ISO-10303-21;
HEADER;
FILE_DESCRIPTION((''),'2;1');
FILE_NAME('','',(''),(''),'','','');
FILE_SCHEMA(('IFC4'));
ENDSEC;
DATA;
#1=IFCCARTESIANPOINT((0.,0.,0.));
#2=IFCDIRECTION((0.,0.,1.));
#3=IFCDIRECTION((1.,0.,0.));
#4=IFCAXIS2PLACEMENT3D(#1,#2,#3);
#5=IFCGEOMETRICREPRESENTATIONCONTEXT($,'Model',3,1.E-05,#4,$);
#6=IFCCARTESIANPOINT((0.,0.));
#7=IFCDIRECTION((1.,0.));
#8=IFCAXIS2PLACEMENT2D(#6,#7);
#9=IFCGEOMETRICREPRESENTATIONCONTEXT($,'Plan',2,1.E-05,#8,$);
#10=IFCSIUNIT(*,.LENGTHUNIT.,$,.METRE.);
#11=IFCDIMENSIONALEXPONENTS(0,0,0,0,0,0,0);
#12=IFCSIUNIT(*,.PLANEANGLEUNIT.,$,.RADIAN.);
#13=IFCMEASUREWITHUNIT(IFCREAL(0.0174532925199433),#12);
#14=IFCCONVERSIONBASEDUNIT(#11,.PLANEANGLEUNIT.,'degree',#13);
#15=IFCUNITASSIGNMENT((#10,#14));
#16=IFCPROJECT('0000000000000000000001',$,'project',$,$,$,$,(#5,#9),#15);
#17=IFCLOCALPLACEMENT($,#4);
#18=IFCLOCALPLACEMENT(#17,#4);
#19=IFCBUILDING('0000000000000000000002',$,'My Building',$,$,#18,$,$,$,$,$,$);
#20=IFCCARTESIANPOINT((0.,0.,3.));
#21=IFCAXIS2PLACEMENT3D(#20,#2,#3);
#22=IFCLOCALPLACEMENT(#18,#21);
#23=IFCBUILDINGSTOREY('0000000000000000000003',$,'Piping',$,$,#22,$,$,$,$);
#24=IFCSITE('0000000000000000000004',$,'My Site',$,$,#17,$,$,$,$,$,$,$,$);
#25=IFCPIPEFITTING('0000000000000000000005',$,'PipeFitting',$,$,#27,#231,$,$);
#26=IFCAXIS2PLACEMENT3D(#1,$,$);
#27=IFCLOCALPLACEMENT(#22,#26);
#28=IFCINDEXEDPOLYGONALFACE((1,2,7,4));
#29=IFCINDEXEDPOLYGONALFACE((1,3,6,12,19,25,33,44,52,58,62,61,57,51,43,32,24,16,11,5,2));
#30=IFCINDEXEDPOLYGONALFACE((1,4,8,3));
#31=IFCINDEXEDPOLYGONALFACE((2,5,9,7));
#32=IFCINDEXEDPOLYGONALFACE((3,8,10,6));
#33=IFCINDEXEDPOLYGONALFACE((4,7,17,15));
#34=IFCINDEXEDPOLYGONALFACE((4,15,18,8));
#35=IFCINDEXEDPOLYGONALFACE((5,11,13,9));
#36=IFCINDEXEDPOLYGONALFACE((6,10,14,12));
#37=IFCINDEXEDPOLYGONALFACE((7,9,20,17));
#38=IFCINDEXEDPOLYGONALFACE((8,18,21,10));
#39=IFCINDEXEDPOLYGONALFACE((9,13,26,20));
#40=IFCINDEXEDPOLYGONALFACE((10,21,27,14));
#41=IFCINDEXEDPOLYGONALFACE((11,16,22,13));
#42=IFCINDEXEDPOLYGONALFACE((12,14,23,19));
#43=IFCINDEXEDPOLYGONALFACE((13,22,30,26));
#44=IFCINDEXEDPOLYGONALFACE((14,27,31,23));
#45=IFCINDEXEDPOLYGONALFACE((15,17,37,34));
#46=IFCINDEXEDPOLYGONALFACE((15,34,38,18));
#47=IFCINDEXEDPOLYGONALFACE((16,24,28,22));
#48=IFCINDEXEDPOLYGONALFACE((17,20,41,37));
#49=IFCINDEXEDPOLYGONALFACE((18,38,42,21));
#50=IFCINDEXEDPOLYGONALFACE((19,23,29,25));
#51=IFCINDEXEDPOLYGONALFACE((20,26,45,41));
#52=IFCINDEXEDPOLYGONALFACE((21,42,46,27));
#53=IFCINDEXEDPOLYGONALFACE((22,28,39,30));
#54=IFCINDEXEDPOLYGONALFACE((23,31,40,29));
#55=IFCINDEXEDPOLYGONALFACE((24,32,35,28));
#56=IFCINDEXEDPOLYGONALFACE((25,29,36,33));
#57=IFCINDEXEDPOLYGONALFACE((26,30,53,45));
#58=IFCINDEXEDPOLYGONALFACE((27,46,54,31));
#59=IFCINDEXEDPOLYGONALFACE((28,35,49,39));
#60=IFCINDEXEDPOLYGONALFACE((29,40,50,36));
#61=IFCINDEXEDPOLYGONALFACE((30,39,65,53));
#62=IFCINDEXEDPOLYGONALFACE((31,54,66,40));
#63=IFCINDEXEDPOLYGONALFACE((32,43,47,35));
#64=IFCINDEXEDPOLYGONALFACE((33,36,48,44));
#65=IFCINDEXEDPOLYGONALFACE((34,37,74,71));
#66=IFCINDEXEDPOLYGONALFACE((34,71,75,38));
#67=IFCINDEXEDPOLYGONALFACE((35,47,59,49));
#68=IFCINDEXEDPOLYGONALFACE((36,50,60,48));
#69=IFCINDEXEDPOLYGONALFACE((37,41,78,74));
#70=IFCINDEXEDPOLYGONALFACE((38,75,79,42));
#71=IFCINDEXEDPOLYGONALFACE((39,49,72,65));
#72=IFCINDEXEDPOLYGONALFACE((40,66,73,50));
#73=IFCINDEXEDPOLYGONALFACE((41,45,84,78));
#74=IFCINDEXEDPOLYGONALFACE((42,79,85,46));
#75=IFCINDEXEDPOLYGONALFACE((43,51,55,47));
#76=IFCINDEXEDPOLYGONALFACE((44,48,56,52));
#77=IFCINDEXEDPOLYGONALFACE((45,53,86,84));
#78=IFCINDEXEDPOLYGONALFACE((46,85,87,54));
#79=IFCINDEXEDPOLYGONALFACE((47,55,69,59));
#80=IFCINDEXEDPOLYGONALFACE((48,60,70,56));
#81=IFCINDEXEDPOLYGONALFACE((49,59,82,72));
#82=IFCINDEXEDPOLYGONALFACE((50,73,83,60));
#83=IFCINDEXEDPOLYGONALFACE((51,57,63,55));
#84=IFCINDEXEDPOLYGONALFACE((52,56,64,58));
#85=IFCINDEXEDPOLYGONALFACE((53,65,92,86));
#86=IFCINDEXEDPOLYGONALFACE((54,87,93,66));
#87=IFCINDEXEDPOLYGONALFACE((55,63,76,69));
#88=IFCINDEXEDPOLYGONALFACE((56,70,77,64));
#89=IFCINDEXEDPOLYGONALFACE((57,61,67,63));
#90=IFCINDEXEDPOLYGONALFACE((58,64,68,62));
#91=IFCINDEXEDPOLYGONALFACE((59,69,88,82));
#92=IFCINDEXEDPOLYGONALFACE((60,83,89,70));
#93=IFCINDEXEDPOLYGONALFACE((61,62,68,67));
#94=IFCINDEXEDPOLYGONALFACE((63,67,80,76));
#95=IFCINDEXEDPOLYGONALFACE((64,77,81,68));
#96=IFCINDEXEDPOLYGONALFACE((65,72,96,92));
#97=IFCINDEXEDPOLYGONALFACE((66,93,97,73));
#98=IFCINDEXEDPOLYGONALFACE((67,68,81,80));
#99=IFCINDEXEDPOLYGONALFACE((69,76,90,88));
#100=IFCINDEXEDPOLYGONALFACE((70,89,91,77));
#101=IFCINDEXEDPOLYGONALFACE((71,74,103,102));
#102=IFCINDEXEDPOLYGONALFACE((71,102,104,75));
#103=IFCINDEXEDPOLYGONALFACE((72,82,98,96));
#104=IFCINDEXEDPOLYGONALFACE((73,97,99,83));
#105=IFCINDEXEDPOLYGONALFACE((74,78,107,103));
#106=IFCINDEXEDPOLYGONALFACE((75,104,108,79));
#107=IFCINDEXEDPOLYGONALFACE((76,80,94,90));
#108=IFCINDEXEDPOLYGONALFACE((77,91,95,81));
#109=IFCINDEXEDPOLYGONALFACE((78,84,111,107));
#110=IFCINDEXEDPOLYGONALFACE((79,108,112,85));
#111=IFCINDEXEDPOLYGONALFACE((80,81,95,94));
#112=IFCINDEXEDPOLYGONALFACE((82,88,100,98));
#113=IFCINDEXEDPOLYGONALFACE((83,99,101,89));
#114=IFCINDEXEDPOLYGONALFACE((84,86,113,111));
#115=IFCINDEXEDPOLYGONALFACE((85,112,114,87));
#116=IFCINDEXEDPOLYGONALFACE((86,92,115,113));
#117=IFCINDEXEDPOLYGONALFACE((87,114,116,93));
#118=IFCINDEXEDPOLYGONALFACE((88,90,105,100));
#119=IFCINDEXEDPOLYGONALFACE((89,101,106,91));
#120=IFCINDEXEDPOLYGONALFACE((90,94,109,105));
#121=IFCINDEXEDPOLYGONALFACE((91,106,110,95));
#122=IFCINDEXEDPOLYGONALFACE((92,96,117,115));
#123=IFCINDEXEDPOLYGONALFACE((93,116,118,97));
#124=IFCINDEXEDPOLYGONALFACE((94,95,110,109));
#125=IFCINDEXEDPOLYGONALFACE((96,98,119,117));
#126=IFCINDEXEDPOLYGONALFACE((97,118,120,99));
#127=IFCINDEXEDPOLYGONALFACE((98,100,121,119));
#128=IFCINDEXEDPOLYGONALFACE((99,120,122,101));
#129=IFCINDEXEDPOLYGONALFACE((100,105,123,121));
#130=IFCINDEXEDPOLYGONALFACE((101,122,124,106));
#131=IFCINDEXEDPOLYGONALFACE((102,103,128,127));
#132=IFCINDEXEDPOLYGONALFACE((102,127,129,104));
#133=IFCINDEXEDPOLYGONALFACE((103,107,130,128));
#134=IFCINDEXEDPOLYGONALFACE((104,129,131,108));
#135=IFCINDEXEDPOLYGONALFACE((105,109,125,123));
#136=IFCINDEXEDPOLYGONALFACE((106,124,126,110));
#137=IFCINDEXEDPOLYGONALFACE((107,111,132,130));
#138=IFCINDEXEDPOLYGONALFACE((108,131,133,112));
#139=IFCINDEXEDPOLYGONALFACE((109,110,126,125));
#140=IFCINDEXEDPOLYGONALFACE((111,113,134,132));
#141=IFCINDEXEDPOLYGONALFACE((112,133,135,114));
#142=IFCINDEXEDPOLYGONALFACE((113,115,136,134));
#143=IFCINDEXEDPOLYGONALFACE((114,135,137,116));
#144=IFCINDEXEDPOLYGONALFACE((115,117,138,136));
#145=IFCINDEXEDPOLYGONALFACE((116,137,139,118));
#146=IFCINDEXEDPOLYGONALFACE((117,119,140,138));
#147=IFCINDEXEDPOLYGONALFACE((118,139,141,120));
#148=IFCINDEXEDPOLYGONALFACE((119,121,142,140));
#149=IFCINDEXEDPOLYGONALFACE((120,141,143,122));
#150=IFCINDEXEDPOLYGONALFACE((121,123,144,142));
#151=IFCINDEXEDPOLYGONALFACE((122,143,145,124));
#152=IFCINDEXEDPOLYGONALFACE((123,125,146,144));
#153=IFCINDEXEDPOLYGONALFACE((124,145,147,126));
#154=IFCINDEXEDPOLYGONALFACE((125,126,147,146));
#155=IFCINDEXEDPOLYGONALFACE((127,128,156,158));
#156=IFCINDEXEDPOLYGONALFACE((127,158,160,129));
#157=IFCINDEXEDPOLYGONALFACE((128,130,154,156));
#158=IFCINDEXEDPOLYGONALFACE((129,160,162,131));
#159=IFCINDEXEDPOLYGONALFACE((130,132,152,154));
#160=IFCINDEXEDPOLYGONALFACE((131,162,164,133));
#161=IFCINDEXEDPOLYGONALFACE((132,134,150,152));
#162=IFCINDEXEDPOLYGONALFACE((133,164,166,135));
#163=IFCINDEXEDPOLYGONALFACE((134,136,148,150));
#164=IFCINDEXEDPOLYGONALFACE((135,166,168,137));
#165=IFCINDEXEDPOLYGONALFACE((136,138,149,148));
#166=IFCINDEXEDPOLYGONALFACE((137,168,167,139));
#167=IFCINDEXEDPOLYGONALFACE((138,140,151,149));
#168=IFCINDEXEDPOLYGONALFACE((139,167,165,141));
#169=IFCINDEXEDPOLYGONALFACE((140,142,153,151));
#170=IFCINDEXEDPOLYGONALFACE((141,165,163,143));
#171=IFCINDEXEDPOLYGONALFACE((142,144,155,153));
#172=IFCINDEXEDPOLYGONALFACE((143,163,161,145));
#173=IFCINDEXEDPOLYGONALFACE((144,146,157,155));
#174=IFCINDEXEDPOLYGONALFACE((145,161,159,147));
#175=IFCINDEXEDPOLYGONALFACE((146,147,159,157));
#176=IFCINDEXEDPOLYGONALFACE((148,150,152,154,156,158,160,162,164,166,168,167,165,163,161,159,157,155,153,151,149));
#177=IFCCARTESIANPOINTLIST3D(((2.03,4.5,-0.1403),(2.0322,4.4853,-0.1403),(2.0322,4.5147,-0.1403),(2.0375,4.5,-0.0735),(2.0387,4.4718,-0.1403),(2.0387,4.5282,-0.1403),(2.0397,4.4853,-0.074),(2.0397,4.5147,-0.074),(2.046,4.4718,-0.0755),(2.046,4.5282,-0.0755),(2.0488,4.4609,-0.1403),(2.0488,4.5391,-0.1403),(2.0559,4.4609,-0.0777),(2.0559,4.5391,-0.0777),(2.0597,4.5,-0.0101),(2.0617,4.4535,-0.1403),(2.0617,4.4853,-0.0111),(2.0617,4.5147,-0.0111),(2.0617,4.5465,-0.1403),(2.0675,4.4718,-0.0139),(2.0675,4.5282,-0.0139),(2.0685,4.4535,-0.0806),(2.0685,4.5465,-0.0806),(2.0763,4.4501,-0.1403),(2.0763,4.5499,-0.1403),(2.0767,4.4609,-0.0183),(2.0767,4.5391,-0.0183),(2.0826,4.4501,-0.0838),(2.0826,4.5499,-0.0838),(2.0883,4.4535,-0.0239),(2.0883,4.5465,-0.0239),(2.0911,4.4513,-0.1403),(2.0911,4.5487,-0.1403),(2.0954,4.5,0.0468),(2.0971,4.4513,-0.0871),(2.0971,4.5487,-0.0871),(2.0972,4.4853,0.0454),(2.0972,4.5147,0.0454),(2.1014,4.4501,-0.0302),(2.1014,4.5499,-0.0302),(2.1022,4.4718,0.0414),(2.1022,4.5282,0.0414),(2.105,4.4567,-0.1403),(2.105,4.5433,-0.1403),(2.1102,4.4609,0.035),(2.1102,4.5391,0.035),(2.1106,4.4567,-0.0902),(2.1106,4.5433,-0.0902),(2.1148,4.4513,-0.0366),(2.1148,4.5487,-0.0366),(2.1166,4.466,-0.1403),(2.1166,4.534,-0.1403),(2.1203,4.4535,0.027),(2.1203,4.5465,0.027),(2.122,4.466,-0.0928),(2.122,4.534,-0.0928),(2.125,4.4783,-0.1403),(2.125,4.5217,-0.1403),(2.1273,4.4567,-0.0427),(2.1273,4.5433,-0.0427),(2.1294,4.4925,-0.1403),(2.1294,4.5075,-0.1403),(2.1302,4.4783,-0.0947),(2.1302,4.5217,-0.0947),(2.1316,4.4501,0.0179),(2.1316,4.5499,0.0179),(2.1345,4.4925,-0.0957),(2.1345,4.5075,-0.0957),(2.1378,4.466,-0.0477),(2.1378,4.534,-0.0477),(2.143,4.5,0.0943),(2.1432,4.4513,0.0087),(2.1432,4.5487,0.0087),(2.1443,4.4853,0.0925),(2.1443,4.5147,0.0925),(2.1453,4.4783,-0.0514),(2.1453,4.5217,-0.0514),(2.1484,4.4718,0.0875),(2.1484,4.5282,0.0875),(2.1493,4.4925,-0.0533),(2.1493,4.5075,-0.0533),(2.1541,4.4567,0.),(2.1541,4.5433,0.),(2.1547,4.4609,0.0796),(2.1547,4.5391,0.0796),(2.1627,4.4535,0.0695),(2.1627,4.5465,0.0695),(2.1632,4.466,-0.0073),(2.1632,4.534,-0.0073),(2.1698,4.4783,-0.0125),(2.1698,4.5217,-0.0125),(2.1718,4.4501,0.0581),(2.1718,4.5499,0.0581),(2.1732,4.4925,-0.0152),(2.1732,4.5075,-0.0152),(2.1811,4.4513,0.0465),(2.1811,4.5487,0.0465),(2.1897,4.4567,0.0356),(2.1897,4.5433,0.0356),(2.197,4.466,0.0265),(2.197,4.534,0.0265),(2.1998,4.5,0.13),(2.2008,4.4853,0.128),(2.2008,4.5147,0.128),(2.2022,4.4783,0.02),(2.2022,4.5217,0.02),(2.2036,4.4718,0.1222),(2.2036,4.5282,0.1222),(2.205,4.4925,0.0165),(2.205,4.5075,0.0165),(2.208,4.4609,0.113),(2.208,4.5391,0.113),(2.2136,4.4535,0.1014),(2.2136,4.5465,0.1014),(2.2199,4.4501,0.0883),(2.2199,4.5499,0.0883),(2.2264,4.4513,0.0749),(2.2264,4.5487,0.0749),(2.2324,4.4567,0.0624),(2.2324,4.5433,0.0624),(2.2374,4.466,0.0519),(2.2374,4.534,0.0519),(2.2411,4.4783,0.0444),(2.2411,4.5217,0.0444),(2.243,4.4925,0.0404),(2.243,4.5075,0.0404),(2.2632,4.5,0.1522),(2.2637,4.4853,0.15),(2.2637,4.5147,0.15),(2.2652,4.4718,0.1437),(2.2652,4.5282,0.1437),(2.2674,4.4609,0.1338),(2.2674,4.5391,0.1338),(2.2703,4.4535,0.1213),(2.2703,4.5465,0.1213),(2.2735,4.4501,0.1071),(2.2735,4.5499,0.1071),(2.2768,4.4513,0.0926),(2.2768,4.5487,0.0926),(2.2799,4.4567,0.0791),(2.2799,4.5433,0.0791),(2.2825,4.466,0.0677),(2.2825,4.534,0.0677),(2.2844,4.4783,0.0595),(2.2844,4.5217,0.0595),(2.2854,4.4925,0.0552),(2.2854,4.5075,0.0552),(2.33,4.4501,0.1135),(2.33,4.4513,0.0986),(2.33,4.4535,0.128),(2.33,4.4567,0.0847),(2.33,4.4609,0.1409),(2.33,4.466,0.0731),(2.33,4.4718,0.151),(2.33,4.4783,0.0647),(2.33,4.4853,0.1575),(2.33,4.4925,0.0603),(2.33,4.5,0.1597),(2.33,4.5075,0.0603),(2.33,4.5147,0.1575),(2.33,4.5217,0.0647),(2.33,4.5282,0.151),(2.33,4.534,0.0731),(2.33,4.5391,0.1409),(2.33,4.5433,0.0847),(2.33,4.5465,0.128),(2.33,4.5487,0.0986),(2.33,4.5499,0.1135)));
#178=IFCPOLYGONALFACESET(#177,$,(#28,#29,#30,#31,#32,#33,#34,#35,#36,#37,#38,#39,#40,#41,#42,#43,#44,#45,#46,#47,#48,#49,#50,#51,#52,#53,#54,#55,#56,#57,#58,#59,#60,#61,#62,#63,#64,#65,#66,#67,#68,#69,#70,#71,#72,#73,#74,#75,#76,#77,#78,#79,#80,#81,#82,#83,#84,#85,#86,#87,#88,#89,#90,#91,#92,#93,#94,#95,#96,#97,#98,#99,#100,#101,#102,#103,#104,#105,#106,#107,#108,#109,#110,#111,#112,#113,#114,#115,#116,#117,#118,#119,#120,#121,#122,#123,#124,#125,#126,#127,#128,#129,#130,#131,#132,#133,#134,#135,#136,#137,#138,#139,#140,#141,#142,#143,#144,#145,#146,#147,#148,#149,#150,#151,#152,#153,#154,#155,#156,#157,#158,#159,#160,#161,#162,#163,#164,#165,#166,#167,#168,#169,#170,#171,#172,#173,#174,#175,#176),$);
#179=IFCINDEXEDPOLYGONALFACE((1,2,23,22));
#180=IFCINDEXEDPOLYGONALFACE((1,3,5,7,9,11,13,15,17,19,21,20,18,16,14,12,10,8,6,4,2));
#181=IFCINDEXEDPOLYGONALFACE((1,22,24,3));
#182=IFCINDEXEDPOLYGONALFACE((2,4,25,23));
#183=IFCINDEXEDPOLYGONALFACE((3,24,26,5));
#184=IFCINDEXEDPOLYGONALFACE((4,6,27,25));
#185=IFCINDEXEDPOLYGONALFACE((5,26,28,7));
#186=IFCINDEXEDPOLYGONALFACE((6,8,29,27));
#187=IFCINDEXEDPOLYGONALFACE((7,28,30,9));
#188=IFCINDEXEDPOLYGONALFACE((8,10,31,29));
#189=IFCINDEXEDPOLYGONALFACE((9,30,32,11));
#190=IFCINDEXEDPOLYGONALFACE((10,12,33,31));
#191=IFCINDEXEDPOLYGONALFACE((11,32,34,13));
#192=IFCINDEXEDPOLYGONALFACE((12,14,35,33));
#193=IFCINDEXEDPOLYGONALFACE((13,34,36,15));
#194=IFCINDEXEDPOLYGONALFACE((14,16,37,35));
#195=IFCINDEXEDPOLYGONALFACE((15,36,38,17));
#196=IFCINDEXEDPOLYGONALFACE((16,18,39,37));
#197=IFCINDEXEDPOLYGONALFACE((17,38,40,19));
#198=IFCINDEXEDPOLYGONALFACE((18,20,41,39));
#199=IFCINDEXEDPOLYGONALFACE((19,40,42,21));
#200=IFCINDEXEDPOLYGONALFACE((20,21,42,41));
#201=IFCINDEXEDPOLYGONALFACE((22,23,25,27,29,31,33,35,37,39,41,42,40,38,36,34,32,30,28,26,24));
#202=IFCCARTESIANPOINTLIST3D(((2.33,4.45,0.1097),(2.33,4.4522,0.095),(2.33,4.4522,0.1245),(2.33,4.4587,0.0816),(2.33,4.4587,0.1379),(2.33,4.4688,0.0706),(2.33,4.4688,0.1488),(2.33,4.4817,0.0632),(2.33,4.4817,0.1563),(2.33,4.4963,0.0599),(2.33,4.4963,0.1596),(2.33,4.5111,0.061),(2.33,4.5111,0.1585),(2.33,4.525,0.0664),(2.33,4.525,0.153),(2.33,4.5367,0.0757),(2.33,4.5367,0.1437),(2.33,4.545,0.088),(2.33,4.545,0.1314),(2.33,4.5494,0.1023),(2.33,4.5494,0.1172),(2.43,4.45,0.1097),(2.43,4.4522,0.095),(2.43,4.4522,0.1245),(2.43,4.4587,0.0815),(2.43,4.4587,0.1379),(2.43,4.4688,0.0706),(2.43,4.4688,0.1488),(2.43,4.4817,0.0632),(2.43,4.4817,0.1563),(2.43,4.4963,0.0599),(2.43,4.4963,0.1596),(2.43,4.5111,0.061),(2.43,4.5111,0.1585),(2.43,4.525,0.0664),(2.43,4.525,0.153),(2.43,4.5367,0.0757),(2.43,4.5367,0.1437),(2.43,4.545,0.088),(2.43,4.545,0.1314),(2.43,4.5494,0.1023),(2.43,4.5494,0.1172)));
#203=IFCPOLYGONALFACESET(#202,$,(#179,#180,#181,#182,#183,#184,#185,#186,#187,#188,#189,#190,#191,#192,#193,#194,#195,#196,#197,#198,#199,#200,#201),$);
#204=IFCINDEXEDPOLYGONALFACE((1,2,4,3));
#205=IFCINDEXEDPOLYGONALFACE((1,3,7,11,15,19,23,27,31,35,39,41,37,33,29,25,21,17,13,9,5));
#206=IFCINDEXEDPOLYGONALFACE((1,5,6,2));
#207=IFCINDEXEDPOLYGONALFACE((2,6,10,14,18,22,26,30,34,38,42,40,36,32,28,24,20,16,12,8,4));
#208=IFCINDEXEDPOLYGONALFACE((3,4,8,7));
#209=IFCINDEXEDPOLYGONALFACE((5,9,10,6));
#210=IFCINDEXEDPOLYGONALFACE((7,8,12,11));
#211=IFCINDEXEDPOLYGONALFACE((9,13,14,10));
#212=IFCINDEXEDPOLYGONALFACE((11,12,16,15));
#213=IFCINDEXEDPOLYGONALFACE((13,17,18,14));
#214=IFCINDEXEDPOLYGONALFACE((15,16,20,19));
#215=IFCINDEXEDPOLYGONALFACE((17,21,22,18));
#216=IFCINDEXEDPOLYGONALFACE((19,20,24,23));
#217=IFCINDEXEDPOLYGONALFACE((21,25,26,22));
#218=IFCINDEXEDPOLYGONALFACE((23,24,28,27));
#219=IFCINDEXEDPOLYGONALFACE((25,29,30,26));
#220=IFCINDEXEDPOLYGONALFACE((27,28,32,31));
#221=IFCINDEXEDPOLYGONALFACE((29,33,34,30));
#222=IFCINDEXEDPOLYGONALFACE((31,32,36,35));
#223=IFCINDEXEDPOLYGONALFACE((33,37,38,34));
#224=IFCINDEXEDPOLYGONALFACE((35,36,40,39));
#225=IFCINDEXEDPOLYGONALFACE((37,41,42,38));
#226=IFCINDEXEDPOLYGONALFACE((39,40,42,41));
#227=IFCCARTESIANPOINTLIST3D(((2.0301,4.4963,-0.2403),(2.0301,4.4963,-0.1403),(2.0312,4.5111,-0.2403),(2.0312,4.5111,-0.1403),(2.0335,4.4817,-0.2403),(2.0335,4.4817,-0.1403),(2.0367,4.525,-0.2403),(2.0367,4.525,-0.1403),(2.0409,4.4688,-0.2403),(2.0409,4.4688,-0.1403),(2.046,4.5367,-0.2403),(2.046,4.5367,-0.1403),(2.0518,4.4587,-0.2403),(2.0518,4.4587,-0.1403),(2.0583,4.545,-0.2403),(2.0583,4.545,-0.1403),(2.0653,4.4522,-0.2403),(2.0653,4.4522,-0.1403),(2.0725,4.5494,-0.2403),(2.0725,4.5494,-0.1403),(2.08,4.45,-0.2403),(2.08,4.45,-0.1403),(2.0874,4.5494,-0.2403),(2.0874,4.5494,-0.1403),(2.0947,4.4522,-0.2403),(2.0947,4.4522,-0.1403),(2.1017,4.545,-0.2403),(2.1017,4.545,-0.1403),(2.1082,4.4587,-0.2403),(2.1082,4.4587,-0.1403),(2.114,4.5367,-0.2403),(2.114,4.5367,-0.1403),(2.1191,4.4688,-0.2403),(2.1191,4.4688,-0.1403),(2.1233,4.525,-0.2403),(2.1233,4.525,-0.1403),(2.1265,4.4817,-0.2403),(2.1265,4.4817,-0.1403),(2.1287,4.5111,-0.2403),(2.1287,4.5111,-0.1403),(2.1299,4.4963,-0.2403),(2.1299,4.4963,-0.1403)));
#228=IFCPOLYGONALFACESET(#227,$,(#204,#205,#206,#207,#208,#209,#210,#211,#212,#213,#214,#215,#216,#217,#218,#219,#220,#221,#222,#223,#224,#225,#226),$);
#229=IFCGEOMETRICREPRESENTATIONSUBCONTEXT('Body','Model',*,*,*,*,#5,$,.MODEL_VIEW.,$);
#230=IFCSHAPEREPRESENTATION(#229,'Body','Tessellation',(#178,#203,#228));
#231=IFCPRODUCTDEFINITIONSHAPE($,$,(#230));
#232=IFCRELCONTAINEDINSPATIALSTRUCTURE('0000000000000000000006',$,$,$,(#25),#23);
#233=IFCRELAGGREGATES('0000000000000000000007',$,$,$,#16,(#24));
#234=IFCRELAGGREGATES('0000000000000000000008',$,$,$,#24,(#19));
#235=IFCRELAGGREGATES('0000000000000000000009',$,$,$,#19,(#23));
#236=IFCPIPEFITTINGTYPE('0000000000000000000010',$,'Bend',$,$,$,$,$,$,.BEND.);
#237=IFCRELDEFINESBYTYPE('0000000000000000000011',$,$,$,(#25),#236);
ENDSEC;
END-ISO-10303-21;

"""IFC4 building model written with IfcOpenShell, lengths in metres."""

from ifc_helpers import new_model, entity, si_unit, converted_unit, frame, origin_with_axes, origin_2d_with_axis, place, context, subcontext, project, spatial, circle, extrude, source, transform, mapped, type_object, type_shapes, element, save


model = new_model("IFC4")

# Units and contexts
model_context = context("Model", 3, precision=1e-05, world=origin_with_axes())
plan_context = context("Plan", 2, precision=1e-05, world=origin_2d_with_axis())
body_context = subcontext(model_context, "Body", "Model", "MODEL_VIEW")
ifc_project = project(units=[si_unit("LENGTHUNIT", "METRE"), converted_unit("PLANEANGLEUNIT", "degree", entity("IfcReal", 0.0174532925199433), si_unit("PLANEANGLEUNIT", "RADIAN"), dimensions=[0, 0, 0, 0, 0, 0, 0])], contexts=[model_context, plan_context])

# Site, building, storey
site_placement = place(None, origin_with_axes())
site = spatial("IfcSite", under=ifc_project, at=site_placement, Name="My Site")
building_placement = place(site_placement, origin_with_axes())
building = spatial("IfcBuilding", under=site, at=building_placement, Name="My Building")
storey_placement = place(building_placement, frame((0.0, 0.0, 3.0), z_axis=(0.0, 0.0, 1.0), x_axis=(1.0, 0.0, 0.0)))
storey = spatial("IfcBuildingStorey", under=building, at=storey_placement, Name="Piping")

# Pipe fitting
pipe_fitting_type_1 = type_object("IfcPipeFittingType", Name="Bend", PredefinedType="BEND")
shared_shape_1 = source(origin_with_axes(), body_context, "Body", "SolidModel", [
    entity("IfcSweptDiskSolid", entity("IfcIndexedPolyCurve", entity("IfcCartesianPointList3D", [[0.0, 0.0, 0.1], [0.0, -0.0732, 0.2768], [0.0, -0.25, 0.35]]), [entity("IfcArcIndex", [1, 2, 3])]), 0.05),
    extrude(circle(Radius=0.05), origin_with_axes(), (0.0, 0.0, 1.0), 0.1),
    extrude(circle(Radius=0.05), frame((0.0, -0.25, 0.35), z_axis=(0.0, -1.0, -0.000021), x_axis=(1.0, 0.0, 0.0)), (0.0, 0.0, 1.0), 0.1),
])
type_shapes(pipe_fitting_type_1, [shared_shape_1])
for number, where, z_axis, x_axis, name in (
    (1, (2.43, 4.5, 0.1097), (-1.0, 0.0, 0.000021), (0.0, -1.0, 0.0), "PipeFitting"),
):
    element("IfcPipeFitting", number, at=place(storey_placement, frame(where, z_axis=z_axis, x_axis=x_axis)), inside=storey, type_object=pipe_fitting_type_1, Name=name, context=body_context, shape_type="MappedRepresentation", body=[
        mapped(shared_shape_1, transform((0.0, 0.0, 0.0), x_axis=(1.0, 0.0, 0.0), y_axis=(0.0, 1.0, 0.0), z_axis=(0.0, 0.0, 1.0), scale=1.0)),
    ])

save(model, "model.ifc")
